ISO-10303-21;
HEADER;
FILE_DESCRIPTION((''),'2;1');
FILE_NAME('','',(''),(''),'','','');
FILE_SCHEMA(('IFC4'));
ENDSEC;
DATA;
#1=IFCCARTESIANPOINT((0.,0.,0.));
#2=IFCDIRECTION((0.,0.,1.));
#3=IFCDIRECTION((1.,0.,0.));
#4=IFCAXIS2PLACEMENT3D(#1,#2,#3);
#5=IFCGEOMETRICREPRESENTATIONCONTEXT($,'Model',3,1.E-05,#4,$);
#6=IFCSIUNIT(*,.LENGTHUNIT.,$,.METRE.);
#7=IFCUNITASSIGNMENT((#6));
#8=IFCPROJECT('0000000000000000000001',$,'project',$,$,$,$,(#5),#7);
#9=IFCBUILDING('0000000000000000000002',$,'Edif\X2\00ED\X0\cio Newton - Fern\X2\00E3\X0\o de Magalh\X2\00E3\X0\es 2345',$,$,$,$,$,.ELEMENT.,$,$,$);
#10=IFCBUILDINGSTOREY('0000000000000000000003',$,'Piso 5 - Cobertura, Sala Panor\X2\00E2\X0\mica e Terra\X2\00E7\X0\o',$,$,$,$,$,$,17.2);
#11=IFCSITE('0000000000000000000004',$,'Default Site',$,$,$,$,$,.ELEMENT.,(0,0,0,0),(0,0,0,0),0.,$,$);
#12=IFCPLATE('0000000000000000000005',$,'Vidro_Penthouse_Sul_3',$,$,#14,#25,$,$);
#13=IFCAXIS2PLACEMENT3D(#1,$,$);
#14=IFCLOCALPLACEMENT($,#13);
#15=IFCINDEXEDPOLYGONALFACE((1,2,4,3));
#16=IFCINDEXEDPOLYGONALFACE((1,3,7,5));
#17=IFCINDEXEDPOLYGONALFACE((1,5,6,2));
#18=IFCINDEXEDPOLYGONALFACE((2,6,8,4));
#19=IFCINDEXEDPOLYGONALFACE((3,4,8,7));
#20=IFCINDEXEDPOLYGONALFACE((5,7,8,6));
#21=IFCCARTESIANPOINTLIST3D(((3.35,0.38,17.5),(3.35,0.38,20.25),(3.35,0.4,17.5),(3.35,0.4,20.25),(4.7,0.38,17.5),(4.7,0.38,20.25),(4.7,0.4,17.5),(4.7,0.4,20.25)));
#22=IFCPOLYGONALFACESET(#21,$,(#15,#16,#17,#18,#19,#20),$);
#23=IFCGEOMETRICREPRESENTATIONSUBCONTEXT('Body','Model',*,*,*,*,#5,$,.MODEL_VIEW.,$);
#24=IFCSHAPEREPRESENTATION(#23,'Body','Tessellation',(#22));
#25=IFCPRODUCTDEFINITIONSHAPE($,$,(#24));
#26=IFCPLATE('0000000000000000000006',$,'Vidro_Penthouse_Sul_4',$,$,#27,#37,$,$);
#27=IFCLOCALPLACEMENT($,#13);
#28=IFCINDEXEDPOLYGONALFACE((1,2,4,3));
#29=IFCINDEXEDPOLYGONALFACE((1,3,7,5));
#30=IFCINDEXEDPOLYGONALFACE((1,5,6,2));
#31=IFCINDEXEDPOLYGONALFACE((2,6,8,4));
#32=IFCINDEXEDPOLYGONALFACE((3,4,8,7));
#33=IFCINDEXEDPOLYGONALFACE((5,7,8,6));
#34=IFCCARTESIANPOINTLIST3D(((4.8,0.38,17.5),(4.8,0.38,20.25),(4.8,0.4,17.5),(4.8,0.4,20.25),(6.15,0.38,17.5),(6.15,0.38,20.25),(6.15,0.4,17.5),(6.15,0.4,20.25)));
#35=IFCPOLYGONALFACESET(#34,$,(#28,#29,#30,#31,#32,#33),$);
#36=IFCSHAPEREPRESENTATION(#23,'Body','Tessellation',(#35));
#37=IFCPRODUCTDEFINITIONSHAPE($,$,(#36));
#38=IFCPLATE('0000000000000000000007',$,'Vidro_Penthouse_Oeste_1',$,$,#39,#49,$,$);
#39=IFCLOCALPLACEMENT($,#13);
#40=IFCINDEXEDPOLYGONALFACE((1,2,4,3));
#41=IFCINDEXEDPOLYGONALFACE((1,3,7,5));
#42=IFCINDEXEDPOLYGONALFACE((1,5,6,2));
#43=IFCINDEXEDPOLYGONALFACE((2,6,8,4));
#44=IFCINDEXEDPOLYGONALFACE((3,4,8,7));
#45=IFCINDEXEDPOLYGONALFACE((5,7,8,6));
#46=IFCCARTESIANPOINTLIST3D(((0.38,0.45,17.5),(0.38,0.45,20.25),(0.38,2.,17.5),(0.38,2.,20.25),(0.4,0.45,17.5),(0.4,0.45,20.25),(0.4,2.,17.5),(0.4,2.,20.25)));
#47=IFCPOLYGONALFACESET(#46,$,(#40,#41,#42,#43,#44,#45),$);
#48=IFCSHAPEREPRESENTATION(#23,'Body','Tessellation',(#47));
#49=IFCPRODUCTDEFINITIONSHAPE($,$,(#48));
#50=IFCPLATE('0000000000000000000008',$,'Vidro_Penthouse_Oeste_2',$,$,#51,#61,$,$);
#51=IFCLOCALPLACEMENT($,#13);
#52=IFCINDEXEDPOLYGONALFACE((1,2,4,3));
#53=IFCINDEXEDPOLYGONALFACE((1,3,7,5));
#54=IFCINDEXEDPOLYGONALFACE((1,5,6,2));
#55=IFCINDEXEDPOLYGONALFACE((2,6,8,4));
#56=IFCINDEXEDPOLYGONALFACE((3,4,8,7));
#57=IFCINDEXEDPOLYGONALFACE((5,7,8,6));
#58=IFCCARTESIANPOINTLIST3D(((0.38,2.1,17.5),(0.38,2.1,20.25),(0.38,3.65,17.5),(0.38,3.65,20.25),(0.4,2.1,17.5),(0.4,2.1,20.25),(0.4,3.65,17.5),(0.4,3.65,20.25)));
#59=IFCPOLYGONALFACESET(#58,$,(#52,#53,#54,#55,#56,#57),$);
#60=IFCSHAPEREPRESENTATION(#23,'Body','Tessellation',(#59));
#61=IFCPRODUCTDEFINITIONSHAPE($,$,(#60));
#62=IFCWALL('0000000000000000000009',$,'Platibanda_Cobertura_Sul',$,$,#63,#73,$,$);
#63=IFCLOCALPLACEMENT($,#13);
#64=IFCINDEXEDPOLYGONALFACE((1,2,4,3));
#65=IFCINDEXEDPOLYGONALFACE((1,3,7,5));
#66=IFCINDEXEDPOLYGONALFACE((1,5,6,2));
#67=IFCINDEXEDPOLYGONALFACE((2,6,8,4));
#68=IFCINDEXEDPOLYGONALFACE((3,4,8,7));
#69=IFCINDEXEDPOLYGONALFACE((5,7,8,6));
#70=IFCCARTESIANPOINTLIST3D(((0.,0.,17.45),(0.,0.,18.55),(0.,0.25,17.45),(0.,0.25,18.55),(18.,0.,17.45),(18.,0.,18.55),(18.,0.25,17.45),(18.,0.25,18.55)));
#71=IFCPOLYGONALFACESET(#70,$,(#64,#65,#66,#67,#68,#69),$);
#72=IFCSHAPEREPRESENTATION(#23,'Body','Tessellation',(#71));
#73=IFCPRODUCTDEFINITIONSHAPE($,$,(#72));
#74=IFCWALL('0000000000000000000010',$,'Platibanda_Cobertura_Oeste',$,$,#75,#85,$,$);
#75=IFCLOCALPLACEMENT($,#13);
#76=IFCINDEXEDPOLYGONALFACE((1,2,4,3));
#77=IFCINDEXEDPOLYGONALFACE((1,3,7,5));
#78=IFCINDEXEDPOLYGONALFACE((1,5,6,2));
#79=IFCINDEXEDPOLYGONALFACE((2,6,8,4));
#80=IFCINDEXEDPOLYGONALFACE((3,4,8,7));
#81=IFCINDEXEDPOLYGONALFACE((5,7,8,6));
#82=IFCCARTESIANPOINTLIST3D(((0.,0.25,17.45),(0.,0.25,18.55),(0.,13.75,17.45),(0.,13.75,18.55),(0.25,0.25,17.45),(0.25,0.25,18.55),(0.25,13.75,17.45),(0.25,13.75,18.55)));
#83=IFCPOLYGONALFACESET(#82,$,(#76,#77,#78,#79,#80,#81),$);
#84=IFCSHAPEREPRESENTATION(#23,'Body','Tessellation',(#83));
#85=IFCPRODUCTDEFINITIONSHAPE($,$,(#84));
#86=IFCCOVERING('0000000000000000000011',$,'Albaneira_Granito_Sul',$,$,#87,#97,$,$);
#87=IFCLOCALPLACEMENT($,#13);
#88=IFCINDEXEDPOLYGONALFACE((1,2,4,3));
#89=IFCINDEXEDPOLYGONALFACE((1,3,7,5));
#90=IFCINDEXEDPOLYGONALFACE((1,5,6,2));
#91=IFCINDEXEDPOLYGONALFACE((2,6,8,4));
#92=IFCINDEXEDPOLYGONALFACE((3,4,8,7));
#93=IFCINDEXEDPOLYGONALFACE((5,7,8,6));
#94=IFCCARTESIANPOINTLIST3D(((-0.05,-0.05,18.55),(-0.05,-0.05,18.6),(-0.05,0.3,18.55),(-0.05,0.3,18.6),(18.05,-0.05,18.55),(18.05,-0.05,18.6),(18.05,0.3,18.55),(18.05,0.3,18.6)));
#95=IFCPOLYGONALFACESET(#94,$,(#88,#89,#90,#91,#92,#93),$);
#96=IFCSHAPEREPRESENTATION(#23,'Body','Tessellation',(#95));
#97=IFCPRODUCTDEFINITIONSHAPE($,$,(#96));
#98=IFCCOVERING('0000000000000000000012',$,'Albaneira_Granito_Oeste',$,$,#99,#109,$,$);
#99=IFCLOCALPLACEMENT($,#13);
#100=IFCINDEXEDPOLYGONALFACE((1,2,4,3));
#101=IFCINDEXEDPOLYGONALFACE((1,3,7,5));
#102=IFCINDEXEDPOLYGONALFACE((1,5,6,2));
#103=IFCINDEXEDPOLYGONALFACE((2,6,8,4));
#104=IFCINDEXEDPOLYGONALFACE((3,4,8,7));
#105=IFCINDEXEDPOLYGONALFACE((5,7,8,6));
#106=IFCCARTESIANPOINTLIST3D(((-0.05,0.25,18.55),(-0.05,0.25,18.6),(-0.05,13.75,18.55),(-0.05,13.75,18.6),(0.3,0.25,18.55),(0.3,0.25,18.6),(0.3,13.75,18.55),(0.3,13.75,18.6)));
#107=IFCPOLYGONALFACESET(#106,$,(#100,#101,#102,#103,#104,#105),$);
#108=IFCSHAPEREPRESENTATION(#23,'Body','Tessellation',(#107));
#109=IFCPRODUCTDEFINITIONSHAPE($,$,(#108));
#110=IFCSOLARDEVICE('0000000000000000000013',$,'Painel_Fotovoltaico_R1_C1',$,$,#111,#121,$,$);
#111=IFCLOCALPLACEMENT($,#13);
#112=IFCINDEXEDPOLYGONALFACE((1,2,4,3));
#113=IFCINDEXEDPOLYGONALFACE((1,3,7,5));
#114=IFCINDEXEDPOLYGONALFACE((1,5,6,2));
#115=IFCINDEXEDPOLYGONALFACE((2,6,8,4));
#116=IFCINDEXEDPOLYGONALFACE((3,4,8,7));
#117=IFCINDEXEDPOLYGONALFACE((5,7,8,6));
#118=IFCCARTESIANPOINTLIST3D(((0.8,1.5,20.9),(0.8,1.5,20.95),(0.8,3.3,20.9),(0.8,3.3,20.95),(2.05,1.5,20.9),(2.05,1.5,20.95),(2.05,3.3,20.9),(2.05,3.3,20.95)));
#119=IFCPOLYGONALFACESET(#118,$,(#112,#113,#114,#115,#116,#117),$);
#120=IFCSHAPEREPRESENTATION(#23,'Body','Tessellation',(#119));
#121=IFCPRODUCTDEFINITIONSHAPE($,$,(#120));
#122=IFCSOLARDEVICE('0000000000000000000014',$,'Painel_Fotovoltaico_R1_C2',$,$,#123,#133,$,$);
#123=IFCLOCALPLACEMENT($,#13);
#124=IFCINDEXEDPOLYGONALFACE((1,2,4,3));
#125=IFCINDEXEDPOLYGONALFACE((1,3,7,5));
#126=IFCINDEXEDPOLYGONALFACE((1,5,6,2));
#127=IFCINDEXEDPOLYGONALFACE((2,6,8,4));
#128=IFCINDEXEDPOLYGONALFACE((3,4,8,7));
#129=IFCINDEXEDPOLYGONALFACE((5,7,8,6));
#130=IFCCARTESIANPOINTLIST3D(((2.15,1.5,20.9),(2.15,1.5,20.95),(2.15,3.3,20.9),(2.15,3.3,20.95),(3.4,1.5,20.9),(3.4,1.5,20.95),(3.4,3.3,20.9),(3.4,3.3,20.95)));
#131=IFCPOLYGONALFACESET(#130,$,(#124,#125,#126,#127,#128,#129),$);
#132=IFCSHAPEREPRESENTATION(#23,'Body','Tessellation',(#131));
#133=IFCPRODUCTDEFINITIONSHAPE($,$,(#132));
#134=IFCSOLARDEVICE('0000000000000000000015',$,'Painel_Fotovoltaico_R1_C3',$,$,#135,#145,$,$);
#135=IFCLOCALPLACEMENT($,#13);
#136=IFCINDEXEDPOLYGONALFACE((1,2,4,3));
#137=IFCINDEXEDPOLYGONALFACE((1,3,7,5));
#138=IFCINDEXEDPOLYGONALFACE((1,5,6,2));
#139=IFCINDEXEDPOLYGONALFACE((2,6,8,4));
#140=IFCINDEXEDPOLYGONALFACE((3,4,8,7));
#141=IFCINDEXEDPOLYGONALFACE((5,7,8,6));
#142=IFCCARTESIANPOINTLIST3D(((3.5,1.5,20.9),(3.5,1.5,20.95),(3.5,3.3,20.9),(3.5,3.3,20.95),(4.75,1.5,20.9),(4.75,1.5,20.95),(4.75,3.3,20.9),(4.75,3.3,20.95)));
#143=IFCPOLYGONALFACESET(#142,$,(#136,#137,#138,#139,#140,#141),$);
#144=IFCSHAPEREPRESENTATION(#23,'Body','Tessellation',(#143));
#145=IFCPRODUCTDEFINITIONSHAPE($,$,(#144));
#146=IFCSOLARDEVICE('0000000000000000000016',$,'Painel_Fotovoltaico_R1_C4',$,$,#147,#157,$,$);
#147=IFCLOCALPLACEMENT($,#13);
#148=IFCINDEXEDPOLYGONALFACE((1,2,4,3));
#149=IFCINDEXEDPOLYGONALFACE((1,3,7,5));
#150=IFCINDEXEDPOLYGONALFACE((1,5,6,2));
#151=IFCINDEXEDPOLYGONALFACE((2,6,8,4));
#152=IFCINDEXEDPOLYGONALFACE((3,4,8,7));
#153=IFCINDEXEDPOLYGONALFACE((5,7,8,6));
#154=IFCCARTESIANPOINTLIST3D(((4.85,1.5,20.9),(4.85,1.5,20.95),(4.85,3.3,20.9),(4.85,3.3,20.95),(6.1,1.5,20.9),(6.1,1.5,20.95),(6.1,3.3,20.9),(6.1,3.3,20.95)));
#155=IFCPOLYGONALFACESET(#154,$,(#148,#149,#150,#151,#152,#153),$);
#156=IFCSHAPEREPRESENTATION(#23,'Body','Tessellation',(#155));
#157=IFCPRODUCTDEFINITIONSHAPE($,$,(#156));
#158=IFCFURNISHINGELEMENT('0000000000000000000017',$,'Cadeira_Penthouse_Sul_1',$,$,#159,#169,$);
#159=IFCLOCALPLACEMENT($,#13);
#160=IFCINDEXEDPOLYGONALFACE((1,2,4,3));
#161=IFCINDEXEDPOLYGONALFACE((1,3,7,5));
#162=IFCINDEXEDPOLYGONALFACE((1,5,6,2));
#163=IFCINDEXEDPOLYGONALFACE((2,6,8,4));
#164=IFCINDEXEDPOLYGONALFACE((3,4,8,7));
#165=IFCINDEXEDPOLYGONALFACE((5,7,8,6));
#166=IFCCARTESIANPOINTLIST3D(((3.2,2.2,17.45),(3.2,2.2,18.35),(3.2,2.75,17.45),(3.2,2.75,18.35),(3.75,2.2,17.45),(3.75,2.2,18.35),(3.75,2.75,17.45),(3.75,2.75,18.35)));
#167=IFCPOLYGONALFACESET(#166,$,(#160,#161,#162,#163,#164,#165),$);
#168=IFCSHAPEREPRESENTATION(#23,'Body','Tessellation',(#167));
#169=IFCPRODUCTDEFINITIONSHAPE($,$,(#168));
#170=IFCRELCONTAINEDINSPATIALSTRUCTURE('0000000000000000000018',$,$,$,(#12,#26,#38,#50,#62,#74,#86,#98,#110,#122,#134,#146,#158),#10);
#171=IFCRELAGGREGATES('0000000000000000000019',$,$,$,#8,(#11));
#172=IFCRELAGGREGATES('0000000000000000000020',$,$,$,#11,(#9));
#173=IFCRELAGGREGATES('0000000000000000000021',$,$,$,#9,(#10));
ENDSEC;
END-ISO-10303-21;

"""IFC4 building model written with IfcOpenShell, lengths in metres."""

from ifc_helpers import new_model, si_unit, frame, frame_2d, origin_with_axes, place, context, subcontext, project, spatial, rectangle, extrude, element, save


model = new_model("IFC4")

# Units and contexts
model_context = context("Model", 3, precision=1e-05, world=origin_with_axes())
body_context = subcontext(model_context, "Body", "Model", "MODEL_VIEW")
ifc_project = project(units=[si_unit("LENGTHUNIT", "METRE")], contexts=[model_context])

# Site, building, storey
site = spatial("IfcSite", under=ifc_project, Name="Default Site", CompositionType="ELEMENT", RefLatitude=(0, 0, 0, 0), RefLongitude=(0, 0, 0, 0), RefElevation=0.0)
building = spatial("IfcBuilding", under=site, Name="Edifício Newton - Fernão de Magalhães 2345", CompositionType="ELEMENT")
storey = spatial("IfcBuildingStorey", under=building, Name="Piso 5 - Cobertura, Sala Panorâmica e Terraço", Elevation=17.2)

# Plates
for number, where, z_axis, x_axis, name in (
    (1, (3.35, 0.38, 17.5), (0.0, 0.0, 1.0), (1.0, 0.0, 0.0), "Vidro_Penthouse_Sul_3"),
    (2, (4.8, 0.38, 17.5), (0.0, 0.0, 1.0), (1.0, 0.0, 0.0), "Vidro_Penthouse_Sul_4"),
):
    element("IfcPlate", number, at=place(None, frame(where, z_axis=z_axis, x_axis=x_axis)), inside=storey, Name=name, context=body_context, shape_type="SweptSolid", body=[
        extrude(rectangle(XDim=1.35, YDim=0.02, at=frame_2d((0.675, 0.01))), origin_with_axes(), (0.0, 0.0, 1.0), 2.75),
    ])
for number, where, z_axis, x_axis, name in (
    (3, (0.38, 0.45, 17.5), (0.0, 0.0, 1.0), (1.0, 0.0, 0.0), "Vidro_Penthouse_Oeste_1"),
    (4, (0.38, 2.1, 17.5), (0.0, 0.0, 1.0), (1.0, 0.0, 0.0), "Vidro_Penthouse_Oeste_2"),
):
    element("IfcPlate", number, at=place(None, frame(where, z_axis=z_axis, x_axis=x_axis)), inside=storey, Name=name, context=body_context, shape_type="SweptSolid", body=[
        extrude(rectangle(XDim=0.02, YDim=1.55, at=frame_2d((0.01, 0.775))), origin_with_axes(), (0.0, 0.0, 1.0), 2.75),
    ])

# Walls
wall_1_placement = place(None, frame((0.0, 0.0, 17.45), z_axis=(0.0, 0.0, 1.0), x_axis=(1.0, 0.0, 0.0)))
element("IfcWall", 5, at=wall_1_placement, inside=storey, Name="Platibanda_Cobertura_Sul", context=body_context, shape_type="SweptSolid", body=[
    extrude(rectangle(XDim=18.0, YDim=0.25, at=frame_2d((9.0, 0.125))), origin_with_axes(), (0.0, 0.0, 1.0), 1.1),
])
wall_2_placement = place(None, frame((0.0, 0.25, 17.45), z_axis=(0.0, 0.0, 1.0), x_axis=(1.0, 0.0, 0.0)))
element("IfcWall", 6, at=wall_2_placement, inside=storey, Name="Platibanda_Cobertura_Oeste", context=body_context, shape_type="SweptSolid", body=[
    extrude(rectangle(XDim=0.25, YDim=13.5, at=frame_2d((0.125, 6.75))), origin_with_axes(), (0.0, 0.0, 1.0), 1.1),
])

# Coverings
covering_1_placement = place(None, frame((-0.05, -0.05, 18.55), z_axis=(0.0, 0.0, 1.0), x_axis=(1.0, 0.0, 0.0)))
element("IfcCovering", 7, at=covering_1_placement, inside=storey, Name="Albaneira_Granito_Sul", context=body_context, shape_type="SweptSolid", body=[
    extrude(rectangle(XDim=18.1, YDim=0.35, at=frame_2d((9.05, 0.175))), origin_with_axes(), (0.0, 0.0, 1.0), 0.05),
])
covering_2_placement = place(None, frame((-0.05, 0.25, 18.55), z_axis=(0.0, 0.0, 1.0), x_axis=(1.0, 0.0, 0.0)))
element("IfcCovering", 8, at=covering_2_placement, inside=storey, Name="Albaneira_Granito_Oeste", context=body_context, shape_type="SweptSolid", body=[
    extrude(rectangle(XDim=0.35, YDim=13.5, at=frame_2d((0.175, 6.75))), origin_with_axes(), (0.0, 0.0, 1.0), 0.05),
])

# Solar devices
for number, where, z_axis, x_axis, name in (
    (9, (0.8, 1.5, 20.9), (0.0, 0.0, 1.0), (1.0, 0.0, 0.0), "Painel_Fotovoltaico_R1_C1"),
    (10, (2.15, 1.5, 20.9), (0.0, 0.0, 1.0), (1.0, 0.0, 0.0), "Painel_Fotovoltaico_R1_C2"),
    (11, (3.5, 1.5, 20.9), (0.0, 0.0, 1.0), (1.0, 0.0, 0.0), "Painel_Fotovoltaico_R1_C3"),
    (12, (4.85, 1.5, 20.9), (0.0, 0.0, 1.0), (1.0, 0.0, 0.0), "Painel_Fotovoltaico_R1_C4"),
):
    element("IfcSolarDevice", number, at=place(None, frame(where, z_axis=z_axis, x_axis=x_axis)), inside=storey, Name=name, context=body_context, shape_type="SweptSolid", body=[
        extrude(rectangle(XDim=1.25, YDim=1.8, at=frame_2d((0.625, 0.9))), origin_with_axes(), (0.0, 0.0, 1.0), 0.05),
    ])

# Furnishing element
furnishing_placement = place(None, frame((3.2, 2.2, 17.45), z_axis=(0.0, 0.0, 1.0), x_axis=(1.0, 0.0, 0.0)))
element("IfcFurnishingElement", 13, at=furnishing_placement, inside=storey, Name="Cadeira_Penthouse_Sul_1", context=body_context, shape_type="SweptSolid", body=[
    extrude(rectangle(XDim=0.55, YDim=0.55, at=frame_2d((0.275, 0.275))), origin_with_axes(), (0.0, 0.0, 1.0), 0.9),
])

save(model, "model.ifc")
